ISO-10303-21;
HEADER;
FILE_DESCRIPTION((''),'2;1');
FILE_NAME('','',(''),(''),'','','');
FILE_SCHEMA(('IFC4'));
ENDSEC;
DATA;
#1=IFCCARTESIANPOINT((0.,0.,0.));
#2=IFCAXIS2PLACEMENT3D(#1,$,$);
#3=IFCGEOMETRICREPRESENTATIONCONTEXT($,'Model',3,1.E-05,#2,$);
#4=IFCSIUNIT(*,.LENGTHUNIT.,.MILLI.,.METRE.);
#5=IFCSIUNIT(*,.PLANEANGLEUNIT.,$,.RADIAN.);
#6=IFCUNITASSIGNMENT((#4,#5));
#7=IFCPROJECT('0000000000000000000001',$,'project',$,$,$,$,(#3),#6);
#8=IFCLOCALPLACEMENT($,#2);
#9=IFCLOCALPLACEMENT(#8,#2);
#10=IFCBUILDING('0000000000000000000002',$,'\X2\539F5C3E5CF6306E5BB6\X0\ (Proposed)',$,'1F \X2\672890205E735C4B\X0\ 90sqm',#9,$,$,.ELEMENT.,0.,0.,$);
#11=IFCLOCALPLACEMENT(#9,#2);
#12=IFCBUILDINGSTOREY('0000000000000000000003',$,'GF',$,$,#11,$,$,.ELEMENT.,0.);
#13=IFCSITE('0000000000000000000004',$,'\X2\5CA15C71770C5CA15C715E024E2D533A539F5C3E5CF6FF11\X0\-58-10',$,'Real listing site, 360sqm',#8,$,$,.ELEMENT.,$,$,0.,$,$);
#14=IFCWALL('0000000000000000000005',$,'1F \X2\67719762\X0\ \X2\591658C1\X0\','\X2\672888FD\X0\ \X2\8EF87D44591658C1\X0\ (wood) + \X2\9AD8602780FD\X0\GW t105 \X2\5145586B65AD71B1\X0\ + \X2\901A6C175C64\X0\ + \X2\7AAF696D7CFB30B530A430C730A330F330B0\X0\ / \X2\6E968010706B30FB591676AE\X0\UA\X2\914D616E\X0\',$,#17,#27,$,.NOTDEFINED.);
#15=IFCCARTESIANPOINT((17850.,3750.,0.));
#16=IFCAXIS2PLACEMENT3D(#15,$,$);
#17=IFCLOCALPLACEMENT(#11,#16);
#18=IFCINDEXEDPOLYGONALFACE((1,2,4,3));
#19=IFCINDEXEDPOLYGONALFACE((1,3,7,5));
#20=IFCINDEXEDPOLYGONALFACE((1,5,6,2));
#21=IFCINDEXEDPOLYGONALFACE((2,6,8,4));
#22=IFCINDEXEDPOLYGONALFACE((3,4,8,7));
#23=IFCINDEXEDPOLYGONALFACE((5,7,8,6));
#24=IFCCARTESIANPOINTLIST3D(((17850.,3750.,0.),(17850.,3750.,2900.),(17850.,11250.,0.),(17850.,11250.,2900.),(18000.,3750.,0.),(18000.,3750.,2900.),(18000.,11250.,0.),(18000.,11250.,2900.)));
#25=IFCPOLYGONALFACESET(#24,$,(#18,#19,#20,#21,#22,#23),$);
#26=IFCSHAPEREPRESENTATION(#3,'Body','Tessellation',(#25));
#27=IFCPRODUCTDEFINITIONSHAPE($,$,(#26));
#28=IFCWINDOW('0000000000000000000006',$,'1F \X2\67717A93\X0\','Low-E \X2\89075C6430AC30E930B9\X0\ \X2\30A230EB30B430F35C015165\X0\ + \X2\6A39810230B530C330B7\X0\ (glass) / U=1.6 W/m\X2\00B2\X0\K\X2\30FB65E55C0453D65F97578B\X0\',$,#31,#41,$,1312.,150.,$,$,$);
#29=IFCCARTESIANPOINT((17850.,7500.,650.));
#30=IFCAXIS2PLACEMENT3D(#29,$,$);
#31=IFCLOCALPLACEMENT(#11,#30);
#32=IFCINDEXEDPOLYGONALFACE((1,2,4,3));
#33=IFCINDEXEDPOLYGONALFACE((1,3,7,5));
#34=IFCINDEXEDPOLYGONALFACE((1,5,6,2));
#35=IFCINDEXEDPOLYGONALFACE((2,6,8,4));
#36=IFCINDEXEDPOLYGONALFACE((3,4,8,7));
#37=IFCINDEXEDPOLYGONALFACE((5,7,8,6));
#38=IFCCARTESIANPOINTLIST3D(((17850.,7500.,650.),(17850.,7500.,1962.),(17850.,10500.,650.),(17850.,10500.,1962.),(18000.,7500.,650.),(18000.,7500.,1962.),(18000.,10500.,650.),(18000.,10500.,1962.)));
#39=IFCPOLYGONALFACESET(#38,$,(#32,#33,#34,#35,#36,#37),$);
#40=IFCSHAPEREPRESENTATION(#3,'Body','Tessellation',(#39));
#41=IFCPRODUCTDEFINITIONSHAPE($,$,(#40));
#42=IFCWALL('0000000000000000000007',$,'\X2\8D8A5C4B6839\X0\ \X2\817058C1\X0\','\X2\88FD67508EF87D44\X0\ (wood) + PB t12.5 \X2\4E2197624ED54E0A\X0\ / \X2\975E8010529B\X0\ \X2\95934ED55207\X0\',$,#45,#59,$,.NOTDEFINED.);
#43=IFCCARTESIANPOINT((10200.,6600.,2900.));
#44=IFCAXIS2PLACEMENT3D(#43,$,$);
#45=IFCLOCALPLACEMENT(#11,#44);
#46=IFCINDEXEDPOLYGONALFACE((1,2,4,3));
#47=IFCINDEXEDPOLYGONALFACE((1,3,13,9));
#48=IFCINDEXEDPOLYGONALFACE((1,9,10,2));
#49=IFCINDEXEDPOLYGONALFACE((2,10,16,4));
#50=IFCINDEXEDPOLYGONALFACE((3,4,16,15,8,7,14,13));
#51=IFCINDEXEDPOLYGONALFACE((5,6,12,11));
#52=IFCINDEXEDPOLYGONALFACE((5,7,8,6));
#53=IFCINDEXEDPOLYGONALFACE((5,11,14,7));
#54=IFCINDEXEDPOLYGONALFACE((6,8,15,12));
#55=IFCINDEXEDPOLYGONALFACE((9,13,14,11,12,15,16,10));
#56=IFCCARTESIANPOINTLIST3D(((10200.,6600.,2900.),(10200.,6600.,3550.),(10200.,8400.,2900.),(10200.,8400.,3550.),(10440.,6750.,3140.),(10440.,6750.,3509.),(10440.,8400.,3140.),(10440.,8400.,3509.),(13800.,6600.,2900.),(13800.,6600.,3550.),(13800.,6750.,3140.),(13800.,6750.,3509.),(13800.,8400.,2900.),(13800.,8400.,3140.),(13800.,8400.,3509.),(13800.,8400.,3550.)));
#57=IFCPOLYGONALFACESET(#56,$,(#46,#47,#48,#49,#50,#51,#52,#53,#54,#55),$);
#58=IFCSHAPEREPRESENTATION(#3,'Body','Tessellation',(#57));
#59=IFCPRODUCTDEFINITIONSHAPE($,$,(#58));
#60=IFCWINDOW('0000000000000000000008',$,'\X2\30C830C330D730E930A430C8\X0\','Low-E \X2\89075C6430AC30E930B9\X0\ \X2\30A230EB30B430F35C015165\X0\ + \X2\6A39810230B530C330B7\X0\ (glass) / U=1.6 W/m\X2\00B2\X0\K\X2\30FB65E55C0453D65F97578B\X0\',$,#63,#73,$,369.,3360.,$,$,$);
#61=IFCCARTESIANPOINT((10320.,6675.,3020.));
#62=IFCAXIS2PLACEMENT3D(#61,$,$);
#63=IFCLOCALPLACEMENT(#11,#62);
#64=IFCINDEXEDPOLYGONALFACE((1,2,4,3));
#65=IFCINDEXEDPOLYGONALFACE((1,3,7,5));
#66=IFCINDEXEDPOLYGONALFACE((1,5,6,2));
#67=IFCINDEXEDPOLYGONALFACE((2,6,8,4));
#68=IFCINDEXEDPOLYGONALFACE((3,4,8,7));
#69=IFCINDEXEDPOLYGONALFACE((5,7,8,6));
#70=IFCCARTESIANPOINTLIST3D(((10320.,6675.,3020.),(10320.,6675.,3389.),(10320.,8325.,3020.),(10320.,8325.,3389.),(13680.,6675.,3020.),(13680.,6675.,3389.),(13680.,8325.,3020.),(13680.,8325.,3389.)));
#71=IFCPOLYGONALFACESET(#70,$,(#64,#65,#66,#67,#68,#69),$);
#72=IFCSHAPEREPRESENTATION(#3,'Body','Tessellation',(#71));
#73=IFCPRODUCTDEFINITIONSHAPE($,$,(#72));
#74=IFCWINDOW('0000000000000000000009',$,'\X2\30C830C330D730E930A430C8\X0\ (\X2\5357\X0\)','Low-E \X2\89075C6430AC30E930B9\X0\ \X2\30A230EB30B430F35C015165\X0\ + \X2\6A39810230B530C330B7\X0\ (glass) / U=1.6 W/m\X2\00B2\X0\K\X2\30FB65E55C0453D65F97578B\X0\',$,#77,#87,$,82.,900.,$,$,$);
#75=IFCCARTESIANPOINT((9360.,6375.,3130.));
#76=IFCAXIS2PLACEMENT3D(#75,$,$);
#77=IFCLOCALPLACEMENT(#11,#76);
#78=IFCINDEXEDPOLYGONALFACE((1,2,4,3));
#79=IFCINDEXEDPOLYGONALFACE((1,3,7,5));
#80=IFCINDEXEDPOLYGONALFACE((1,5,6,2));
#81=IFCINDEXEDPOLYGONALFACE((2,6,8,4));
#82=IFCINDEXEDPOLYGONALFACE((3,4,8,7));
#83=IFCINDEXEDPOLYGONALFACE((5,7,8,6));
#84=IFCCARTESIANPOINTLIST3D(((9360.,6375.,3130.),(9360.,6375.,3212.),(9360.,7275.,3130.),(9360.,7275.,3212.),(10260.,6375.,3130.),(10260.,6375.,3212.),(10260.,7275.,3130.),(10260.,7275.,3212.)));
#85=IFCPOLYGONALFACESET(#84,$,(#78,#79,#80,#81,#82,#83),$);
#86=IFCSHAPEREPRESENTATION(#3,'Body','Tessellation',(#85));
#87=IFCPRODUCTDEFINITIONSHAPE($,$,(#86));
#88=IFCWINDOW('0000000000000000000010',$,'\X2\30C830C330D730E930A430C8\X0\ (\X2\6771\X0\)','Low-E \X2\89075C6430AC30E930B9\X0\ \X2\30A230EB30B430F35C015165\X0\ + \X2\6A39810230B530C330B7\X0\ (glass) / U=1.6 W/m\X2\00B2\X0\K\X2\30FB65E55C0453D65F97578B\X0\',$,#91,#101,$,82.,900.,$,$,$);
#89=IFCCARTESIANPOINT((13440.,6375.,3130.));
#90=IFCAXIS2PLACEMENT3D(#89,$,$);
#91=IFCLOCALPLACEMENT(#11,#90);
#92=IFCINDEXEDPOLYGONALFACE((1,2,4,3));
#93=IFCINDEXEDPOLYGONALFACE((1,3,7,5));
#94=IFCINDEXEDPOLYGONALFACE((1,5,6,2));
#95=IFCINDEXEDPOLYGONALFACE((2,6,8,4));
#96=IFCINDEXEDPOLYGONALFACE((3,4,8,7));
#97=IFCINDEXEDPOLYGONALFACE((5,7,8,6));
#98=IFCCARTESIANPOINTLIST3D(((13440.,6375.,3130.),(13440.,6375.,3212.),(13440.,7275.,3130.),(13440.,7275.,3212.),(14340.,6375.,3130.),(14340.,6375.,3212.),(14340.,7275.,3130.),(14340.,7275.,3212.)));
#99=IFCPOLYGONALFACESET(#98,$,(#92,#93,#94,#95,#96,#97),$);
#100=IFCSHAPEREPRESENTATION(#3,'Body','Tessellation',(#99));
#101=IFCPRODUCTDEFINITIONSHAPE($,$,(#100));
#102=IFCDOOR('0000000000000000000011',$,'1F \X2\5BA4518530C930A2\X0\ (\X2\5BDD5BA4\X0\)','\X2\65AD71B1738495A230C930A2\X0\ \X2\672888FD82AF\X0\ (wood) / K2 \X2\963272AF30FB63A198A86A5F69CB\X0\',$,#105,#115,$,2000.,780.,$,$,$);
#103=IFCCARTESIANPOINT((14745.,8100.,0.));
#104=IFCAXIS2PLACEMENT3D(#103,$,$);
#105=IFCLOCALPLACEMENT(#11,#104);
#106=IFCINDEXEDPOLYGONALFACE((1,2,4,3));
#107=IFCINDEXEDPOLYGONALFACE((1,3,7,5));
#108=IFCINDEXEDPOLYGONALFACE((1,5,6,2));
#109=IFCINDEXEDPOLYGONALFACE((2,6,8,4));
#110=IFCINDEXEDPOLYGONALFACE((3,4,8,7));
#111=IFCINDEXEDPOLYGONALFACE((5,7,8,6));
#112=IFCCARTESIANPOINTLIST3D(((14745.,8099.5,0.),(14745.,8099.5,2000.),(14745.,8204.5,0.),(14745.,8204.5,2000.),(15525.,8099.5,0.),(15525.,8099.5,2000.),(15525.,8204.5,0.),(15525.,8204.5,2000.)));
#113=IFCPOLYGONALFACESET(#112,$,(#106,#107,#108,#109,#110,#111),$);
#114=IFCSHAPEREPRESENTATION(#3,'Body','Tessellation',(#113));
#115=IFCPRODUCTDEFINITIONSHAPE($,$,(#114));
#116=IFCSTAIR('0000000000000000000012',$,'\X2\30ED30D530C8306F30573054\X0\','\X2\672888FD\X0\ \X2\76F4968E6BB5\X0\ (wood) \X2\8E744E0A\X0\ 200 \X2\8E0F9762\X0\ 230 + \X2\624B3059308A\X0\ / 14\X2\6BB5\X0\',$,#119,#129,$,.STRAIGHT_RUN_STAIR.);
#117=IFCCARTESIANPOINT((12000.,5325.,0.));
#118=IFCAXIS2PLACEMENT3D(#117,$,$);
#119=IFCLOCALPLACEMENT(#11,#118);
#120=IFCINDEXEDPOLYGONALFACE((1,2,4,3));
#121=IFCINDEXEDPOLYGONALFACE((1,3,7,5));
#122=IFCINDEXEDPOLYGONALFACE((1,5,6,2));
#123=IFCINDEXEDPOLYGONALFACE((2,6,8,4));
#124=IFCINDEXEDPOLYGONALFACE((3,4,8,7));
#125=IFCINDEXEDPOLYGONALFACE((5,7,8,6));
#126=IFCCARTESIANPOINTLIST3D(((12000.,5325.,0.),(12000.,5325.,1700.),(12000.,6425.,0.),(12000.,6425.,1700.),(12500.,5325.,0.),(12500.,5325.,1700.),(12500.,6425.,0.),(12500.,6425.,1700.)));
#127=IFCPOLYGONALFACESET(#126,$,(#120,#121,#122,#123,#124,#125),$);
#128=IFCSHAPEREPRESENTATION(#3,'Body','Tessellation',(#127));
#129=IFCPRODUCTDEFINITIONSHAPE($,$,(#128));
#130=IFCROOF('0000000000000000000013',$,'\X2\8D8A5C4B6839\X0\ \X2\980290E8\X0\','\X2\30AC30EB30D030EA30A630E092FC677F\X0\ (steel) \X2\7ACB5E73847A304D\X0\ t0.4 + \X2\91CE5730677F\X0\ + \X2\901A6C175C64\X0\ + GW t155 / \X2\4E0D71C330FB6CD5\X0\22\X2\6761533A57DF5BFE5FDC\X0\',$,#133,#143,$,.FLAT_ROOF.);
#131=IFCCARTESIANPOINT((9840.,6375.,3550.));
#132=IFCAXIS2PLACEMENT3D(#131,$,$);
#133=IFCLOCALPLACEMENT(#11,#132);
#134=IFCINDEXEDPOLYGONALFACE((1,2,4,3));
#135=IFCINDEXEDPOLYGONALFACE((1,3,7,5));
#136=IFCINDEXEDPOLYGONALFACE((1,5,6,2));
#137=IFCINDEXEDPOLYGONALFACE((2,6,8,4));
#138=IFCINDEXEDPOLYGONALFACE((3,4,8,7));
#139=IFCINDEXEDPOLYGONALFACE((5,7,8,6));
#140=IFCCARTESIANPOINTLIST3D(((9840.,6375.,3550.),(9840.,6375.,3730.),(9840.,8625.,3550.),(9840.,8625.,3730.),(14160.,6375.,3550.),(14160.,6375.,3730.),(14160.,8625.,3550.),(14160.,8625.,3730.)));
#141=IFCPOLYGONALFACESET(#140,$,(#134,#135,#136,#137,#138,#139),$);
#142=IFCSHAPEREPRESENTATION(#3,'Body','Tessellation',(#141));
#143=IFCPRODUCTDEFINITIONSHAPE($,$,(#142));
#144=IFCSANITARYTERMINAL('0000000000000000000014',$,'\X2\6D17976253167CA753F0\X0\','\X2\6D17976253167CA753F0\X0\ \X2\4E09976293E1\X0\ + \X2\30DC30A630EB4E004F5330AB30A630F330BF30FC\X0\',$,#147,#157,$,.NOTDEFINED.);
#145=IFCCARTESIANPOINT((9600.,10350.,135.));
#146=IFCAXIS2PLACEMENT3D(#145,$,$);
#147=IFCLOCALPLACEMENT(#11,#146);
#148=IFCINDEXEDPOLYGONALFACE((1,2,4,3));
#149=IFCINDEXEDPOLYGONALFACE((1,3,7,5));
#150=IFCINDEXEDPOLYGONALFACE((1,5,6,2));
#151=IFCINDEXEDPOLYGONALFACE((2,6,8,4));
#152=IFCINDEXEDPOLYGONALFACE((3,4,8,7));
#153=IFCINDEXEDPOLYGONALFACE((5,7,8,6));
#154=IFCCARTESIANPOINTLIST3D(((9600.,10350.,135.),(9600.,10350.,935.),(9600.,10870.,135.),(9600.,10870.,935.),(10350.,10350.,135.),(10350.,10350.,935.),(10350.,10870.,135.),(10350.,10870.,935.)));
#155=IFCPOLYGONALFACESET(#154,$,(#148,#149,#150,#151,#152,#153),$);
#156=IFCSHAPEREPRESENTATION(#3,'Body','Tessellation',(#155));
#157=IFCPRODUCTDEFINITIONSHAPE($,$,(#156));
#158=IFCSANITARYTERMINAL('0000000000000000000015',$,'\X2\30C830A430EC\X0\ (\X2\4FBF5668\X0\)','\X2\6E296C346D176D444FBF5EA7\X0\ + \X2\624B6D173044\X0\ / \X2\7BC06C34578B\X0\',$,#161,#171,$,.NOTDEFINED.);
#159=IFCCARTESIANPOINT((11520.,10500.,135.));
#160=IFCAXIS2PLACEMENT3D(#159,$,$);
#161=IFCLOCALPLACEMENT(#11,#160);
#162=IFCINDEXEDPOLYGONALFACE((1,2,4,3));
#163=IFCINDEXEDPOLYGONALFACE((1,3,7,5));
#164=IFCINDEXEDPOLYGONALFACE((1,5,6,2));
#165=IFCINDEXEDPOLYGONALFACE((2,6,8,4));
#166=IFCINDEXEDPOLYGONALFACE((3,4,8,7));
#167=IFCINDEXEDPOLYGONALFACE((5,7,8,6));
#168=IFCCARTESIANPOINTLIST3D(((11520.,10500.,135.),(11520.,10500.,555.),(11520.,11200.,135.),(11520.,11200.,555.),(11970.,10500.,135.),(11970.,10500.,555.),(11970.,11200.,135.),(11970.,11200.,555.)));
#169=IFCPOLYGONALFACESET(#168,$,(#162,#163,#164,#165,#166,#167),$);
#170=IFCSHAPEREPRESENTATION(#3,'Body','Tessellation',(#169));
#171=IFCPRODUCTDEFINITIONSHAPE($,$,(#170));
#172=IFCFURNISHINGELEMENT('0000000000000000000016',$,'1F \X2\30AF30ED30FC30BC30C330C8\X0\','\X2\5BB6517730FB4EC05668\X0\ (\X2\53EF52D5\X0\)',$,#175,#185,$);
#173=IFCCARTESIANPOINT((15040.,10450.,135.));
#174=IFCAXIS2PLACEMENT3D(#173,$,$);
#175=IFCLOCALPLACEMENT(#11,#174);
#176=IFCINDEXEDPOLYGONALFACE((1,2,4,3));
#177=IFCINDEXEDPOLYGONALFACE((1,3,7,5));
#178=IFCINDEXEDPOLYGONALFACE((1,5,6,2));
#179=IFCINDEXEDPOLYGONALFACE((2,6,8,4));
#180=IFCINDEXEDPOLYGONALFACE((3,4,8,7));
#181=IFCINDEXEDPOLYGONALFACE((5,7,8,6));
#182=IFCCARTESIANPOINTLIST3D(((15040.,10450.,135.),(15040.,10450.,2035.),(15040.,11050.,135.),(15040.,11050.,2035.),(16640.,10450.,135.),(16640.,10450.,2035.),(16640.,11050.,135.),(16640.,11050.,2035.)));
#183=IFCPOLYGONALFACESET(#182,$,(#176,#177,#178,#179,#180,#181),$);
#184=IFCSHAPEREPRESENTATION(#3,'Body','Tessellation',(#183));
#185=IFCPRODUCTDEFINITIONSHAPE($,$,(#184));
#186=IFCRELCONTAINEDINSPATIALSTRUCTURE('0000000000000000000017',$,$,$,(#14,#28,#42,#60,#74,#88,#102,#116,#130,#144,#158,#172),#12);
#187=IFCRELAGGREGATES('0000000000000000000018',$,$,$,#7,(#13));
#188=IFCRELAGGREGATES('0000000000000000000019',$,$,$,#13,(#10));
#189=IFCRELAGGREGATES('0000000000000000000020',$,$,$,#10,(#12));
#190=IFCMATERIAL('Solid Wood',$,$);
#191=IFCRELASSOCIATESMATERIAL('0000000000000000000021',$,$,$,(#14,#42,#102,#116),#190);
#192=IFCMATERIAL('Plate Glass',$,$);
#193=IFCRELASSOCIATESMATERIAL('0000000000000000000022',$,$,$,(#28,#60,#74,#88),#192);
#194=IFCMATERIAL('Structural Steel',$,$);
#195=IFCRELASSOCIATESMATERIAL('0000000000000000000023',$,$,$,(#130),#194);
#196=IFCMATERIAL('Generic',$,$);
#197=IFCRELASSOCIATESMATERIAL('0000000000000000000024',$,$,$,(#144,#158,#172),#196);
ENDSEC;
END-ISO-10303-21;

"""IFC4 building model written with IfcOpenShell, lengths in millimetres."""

from ifc_helpers import new_model, si_unit, frame, frame_2d, origin, place, context, project, spatial, rectangle, extrude, material, element, fill, save


model = new_model("IFC4")

# Units and contexts
model_context = context("Model", 3, precision=1e-05, world=origin())
ifc_project = project(units=[si_unit("LENGTHUNIT", "METRE", prefix="MILLI"), si_unit("PLANEANGLEUNIT", "RADIAN")], contexts=[model_context])

# Site, building, storey
site_placement = place(None, origin())
site = spatial("IfcSite", under=ifc_project, at=site_placement, Name="岡山県岡山市中区原尾島１-58-10", ObjectType="Real listing site, 360sqm", CompositionType="ELEMENT", RefElevation=0.0)
building_placement = place(site_placement, origin())
building = spatial("IfcBuilding", under=site, at=building_placement, Name="原尾島の家 (Proposed)", ObjectType="1F 木造平屋 90sqm", CompositionType="ELEMENT", ElevationOfRefHeight=0.0, ElevationOfTerrain=0.0)
storey_placement = place(building_placement, origin())
storey = spatial("IfcBuildingStorey", under=building, at=storey_placement, Name="GF", CompositionType="ELEMENT", Elevation=0.0)

# Wall, opening, window
ifc_material_1 = material(Name="Solid Wood")
wall_1_placement = place(storey_placement, frame((17850.0, 3750.0, 0.0)))
wall_1 = element("IfcWall", 1, at=wall_1_placement, inside=storey, material=ifc_material_1, Name="1F 東面 外壁", Description="木製 軸組外壁 (wood) + 高性能GW t105 充填断熱 + 通気層 + 窯業系サイディング / 準耐火・外皮UA配慮", PredefinedType="NOTDEFINED", context=model_context, shape_type="SweptSolid", body=[
    extrude(rectangle(XDim=150.0, YDim=7500.0, at=frame_2d((75.0, 3750.0))), frame((17850.0, 3750.0, 0.0)), (0.0, 0.0, 1.0), 2900.0),
])
opening_1_placement = place(storey_placement, frame((17850.0, 7500.0, 650.0)))
opening_1 = element("IfcOpeningElement", 2, at=opening_1_placement, cuts=wall_1, PredefinedType="NOTDEFINED", context=model_context, shape_type="SweptSolid", body=[
    extrude(rectangle(XDim=150.0, YDim=3000.0, at=frame_2d((75.0, 1500.0))), frame((17850.0, 7500.0, 650.0)), (0.0, 0.0, 1.0), 1312.0),
])
ifc_material_2 = material(Name="Plate Glass")
window_1_placement = place(storey_placement, frame((17850.0, 7500.0, 650.0)))
window_1 = element("IfcWindow", 3, at=window_1_placement, inside=storey, material=ifc_material_2, Name="1F 東窓", Description="Low-E 複層ガラス アルゴン封入 + 樹脂サッシ (glass) / U=1.6 W/m²K・日射取得型", OverallHeight=1312.0, OverallWidth=150.0, context=model_context, shape_type="SweptSolid", body=[
    extrude(rectangle(XDim=150.0, YDim=3000.0, at=frame_2d((75.0, 1500.0))), frame((17850.0, 7500.0, 650.0)), (0.0, 0.0, 1.0), 1312.0),
])
fill(opening_1, window_1)

# Wall, openings, windows
wall_2_placement = place(storey_placement, frame((10200.0, 6600.0, 2900.0)))
wall_2 = element("IfcWall", 4, at=wall_2_placement, inside=storey, material=ifc_material_1, Name="越屋根 腰壁", Description="製材軸組 (wood) + PB t12.5 両面仕上 / 非耐力 間仕切", PredefinedType="NOTDEFINED", context=model_context, shape_type="SweptSolid", body=[
    extrude(rectangle(XDim=3600.0, YDim=1800.0, at=frame_2d((1800.0, 900.0))), frame((10200.0, 6600.0, 2900.0)), (0.0, 0.0, 1.0), 650.0),
])
opening_2_placement = place(storey_placement, frame((10320.0, 6675.0, 3020.0)))
opening_2 = element("IfcOpeningElement", 5, at=opening_2_placement, cuts=wall_2, PredefinedType="NOTDEFINED", context=model_context, shape_type="SweptSolid", body=[
    extrude(rectangle(XDim=3360.0, YDim=1650.0, at=frame_2d((1680.0, 825.0))), frame((10320.0, 6675.0, 3020.0)), (0.0, 0.0, 1.0), 369.0),
])
opening_3_placement = place(storey_placement, frame((9360.0, 6375.0, 3130.0)))
opening_3 = element("IfcOpeningElement", 6, at=opening_3_placement, cuts=wall_2, PredefinedType="NOTDEFINED", context=model_context, shape_type="SweptSolid", body=[
    extrude(rectangle(XDim=900.0, YDim=900.0, at=frame_2d((450.0, 450.0))), frame((9360.0, 6375.0, 3130.0)), (0.0, 0.0, 1.0), 82.0),
])
opening_4_placement = place(storey_placement, frame((13440.0, 6375.0, 3130.0)))
opening_4 = element("IfcOpeningElement", 7, at=opening_4_placement, cuts=wall_2, PredefinedType="NOTDEFINED", context=model_context, shape_type="SweptSolid", body=[
    extrude(rectangle(XDim=900.0, YDim=900.0, at=frame_2d((450.0, 450.0))), frame((13440.0, 6375.0, 3130.0)), (0.0, 0.0, 1.0), 82.0),
])
window_2_placement = place(storey_placement, frame((10320.0, 6675.0, 3020.0)))
window_2 = element("IfcWindow", 8, at=window_2_placement, inside=storey, material=ifc_material_2, Name="トップライト", Description="Low-E 複層ガラス アルゴン封入 + 樹脂サッシ (glass) / U=1.6 W/m²K・日射取得型", OverallHeight=369.0, OverallWidth=3360.0, context=model_context, shape_type="SweptSolid", body=[
    extrude(rectangle(XDim=3360.0, YDim=1650.0, at=frame_2d((1680.0, 825.0))), frame((10320.0, 6675.0, 3020.0)), (0.0, 0.0, 1.0), 369.0),
])
fill(opening_2, window_2)
window_3_placement = place(storey_placement, frame((9360.0, 6375.0, 3130.0)))
window_3 = element("IfcWindow", 9, at=window_3_placement, inside=storey, material=ifc_material_2, Name="トップライト (南)", Description="Low-E 複層ガラス アルゴン封入 + 樹脂サッシ (glass) / U=1.6 W/m²K・日射取得型", OverallHeight=82.0, OverallWidth=900.0, context=model_context, shape_type="SweptSolid", body=[
    extrude(rectangle(XDim=900.0, YDim=900.0, at=frame_2d((450.0, 450.0))), frame((9360.0, 6375.0, 3130.0)), (0.0, 0.0, 1.0), 82.0),
])
fill(opening_3, window_3)
window_4_placement = place(storey_placement, frame((13440.0, 6375.0, 3130.0)))
window_4 = element("IfcWindow", 10, at=window_4_placement, inside=storey, material=ifc_material_2, Name="トップライト (東)", Description="Low-E 複層ガラス アルゴン封入 + 樹脂サッシ (glass) / U=1.6 W/m²K・日射取得型", OverallHeight=82.0, OverallWidth=900.0, context=model_context, shape_type="SweptSolid", body=[
    extrude(rectangle(XDim=900.0, YDim=900.0, at=frame_2d((450.0, 450.0))), frame((13440.0, 6375.0, 3130.0)), (0.0, 0.0, 1.0), 82.0),
])
fill(opening_4, window_4)

# Door
door_placement = place(storey_placement, frame((14745.0, 8100.0, 0.0)))
element("IfcDoor", 11, at=door_placement, inside=storey, material=ifc_material_1, Name="1F 室内ドア (寝室)", Description="断熱玄関ドア 木製芯 (wood) / K2 防犯・採風機構", OverallHeight=2000.0, OverallWidth=780.0, context=model_context, shape_type="SweptSolid", body=[
    extrude(rectangle(XDim=780.0, YDim=105.0, at=frame_2d((390.0, 52.0))), frame((14745.0, 8100.0, 0.0)), (0.0, 0.0, 1.0), 2000.0),
])

# Stair
stair_placement = place(storey_placement, frame((12000.0, 5325.0, 0.0)))
element("IfcStair", 12, at=stair_placement, inside=storey, material=ifc_material_1, Name="ロフトはしご", Description="木製 直階段 (wood) 蹴上 200 踏面 230 + 手すり / 14段", PredefinedType="STRAIGHT_RUN_STAIR", context=model_context, shape_type="SweptSolid", body=[
    extrude(rectangle(XDim=500.0, YDim=1100.0, at=frame_2d((250.0, 550.0))), frame((12000.0, 5325.0, 0.0)), (0.0, 0.0, 1.0), 1700.0),
])

# Roof
ifc_material_3 = material(Name="Structural Steel")
roof_placement = place(storey_placement, frame((9840.0, 6375.0, 3550.0)))
element("IfcRoof", 13, at=roof_placement, inside=storey, material=ifc_material_3, Name="越屋根 頂部", Description="ガルバリウム鋼板 (steel) 立平葺き t0.4 + 野地板 + 通気層 + GW t155 / 不燃・法22条区域対応", PredefinedType="FLAT_ROOF", context=model_context, shape_type="SweptSolid", body=[
    extrude(rectangle(XDim=4320.0, YDim=2250.0, at=frame_2d((2160.0, 1125.0))), frame((9840.0, 6375.0, 3550.0)), (0.0, 0.0, 1.0), 180.0),
])

# Sanitary terminals
ifc_material_4 = material(Name="Generic")
sanitary_terminal_1_placement = place(storey_placement, frame((9600.0, 10350.0, 135.0)))
element("IfcSanitaryTerminal", 14, at=sanitary_terminal_1_placement, inside=storey, material=ifc_material_4, Name="洗面化粧台", Description="洗面化粧台 三面鏡 + ボウル一体カウンター", PredefinedType="NOTDEFINED", context=model_context, shape_type="SweptSolid", body=[
    extrude(rectangle(XDim=750.0, YDim=520.0, at=frame_2d((375.0, 260.0))), frame((9600.0, 10350.0, 135.0)), (0.0, 0.0, 1.0), 800.0),
])
sanitary_terminal_2_placement = place(storey_placement, frame((11520.0, 10500.0, 135.0)))
element("IfcSanitaryTerminal", 15, at=sanitary_terminal_2_placement, inside=storey, material=ifc_material_4, Name="トイレ (便器)", Description="温水洗浄便座 + 手洗い / 節水型", PredefinedType="NOTDEFINED", context=model_context, shape_type="SweptSolid", body=[
    extrude(rectangle(XDim=450.0, YDim=700.0, at=frame_2d((225.0, 350.0))), frame((11520.0, 10500.0, 135.0)), (0.0, 0.0, 1.0), 420.0),
])

# Furnishing element
furnishing_1_placement = place(storey_placement, frame((15040.0, 10450.0, 135.0)))
element("IfcFurnishingElement", 16, at=furnishing_1_placement, inside=storey, material=ifc_material_4, Name="1F クローゼット", Description="家具・什器 (可動)", context=model_context, shape_type="SweptSolid", body=[
    extrude(rectangle(XDim=1600.0, YDim=600.0, at=frame_2d((800.0, 300.0))), frame((15040.0, 10450.0, 135.0)), (0.0, 0.0, 1.0), 1900.0),
])

save(model, "model.ifc")
